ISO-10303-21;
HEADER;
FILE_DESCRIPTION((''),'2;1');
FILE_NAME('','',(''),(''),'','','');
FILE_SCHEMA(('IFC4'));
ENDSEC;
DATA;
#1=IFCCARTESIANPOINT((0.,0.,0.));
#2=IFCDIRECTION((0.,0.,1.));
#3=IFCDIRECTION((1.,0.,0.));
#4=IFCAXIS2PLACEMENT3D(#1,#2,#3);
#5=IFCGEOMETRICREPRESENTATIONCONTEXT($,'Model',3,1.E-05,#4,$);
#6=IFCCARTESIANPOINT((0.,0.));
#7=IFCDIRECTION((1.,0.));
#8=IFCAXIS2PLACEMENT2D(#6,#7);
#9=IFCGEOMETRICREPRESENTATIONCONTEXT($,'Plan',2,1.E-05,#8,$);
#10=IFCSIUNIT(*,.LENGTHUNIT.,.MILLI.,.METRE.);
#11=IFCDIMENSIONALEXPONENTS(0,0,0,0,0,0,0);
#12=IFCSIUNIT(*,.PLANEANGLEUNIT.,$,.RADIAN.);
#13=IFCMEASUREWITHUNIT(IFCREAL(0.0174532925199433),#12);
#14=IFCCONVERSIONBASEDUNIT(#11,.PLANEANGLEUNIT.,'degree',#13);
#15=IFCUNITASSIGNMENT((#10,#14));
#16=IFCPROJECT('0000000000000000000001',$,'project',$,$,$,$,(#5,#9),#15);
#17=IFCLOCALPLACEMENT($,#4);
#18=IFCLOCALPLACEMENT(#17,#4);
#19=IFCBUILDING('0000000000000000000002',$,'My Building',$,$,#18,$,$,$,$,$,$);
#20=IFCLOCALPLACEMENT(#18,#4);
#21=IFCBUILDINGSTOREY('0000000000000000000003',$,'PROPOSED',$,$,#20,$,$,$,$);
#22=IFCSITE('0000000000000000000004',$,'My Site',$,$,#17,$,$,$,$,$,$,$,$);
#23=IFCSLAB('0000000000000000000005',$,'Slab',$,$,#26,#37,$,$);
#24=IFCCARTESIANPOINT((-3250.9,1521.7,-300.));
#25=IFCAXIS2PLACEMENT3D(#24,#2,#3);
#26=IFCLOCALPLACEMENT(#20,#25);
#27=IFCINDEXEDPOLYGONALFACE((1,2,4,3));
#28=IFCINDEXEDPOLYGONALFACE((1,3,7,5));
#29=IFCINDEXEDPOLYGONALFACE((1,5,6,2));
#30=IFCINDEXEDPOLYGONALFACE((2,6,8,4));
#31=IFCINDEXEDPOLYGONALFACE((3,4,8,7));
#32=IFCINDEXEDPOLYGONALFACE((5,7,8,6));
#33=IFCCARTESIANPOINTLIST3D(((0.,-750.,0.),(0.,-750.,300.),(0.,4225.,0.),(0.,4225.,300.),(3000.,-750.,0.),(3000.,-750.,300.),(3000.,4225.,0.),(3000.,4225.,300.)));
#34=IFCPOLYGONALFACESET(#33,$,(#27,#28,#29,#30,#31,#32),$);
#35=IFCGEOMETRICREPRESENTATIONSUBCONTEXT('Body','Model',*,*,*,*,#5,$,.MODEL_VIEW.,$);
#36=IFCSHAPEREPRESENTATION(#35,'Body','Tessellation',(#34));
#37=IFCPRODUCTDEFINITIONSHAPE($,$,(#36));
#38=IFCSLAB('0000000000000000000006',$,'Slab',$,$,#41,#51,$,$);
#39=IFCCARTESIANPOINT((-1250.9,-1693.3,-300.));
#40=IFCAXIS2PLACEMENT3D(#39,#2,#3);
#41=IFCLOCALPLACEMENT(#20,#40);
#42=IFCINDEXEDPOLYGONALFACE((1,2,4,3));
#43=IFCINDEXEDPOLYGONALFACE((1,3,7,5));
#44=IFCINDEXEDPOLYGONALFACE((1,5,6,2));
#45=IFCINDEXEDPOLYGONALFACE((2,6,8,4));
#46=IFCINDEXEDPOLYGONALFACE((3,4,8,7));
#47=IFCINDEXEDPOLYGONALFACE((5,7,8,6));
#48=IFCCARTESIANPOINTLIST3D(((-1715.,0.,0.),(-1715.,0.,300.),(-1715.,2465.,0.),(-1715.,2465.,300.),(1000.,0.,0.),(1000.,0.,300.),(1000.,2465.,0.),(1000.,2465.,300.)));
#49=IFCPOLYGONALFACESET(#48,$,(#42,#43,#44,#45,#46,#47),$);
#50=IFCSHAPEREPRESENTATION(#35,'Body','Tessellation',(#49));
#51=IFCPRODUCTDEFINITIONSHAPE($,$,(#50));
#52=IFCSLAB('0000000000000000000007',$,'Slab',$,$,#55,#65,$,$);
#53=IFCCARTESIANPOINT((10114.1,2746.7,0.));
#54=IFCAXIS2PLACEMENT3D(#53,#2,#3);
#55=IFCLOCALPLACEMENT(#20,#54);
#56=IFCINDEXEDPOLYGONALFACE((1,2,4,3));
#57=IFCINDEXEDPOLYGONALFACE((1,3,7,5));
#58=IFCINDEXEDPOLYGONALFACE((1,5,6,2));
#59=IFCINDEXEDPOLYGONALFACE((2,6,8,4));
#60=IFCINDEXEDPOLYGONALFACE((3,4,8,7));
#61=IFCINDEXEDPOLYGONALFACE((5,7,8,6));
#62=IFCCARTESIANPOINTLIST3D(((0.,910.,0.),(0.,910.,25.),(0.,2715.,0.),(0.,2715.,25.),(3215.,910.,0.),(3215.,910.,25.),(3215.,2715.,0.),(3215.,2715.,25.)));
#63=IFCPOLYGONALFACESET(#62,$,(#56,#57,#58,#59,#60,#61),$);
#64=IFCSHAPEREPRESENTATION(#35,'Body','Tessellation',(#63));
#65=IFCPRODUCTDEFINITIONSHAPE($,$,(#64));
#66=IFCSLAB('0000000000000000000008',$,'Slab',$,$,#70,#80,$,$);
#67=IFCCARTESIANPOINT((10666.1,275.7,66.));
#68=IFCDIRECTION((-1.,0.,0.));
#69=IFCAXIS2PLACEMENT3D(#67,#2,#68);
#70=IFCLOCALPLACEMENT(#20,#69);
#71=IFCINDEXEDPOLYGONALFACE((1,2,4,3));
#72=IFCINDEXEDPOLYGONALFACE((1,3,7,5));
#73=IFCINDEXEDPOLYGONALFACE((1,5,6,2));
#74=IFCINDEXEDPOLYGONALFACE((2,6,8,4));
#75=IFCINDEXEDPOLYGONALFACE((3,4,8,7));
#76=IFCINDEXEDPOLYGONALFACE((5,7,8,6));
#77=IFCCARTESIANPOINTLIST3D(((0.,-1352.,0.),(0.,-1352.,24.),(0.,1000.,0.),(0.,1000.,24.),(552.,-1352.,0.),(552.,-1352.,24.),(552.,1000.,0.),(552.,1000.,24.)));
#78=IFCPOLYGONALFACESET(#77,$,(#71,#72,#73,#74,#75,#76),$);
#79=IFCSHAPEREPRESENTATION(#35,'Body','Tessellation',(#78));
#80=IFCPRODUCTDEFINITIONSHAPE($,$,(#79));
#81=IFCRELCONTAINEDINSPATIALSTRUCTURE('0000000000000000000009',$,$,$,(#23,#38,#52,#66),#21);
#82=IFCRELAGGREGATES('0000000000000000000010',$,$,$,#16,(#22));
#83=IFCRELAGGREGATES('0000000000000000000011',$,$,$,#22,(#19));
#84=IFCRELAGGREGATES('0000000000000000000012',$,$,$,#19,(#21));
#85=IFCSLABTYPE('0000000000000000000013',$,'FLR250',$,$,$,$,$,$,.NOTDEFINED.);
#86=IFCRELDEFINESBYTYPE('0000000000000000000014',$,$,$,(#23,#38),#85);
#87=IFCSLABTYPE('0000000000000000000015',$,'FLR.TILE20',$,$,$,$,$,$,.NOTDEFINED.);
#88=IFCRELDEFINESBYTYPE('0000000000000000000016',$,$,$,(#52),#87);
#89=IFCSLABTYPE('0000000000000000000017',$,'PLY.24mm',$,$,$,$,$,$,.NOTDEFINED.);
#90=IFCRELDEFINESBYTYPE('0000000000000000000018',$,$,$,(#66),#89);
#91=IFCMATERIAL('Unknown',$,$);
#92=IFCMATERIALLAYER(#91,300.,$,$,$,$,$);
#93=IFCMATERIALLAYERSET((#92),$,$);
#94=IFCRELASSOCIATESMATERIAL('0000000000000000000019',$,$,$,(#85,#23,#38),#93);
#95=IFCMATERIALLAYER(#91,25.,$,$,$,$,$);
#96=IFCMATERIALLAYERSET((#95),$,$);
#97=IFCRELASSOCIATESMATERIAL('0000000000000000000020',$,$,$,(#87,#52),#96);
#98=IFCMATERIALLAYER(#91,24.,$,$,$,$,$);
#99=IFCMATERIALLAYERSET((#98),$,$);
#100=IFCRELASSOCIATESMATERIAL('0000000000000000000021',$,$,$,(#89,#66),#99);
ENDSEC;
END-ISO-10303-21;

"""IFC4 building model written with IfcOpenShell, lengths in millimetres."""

from ifc_helpers import new_model, entity, si_unit, converted_unit, frame, origin_with_axes, origin_2d_with_axis, place, context, subcontext, project, spatial, line, indexed_curve, outline, extrude, material, layer, layer_set, layer_usage, type_object, element, save


model = new_model("IFC4")

# Units and contexts
model_context = context("Model", 3, precision=1e-05, world=origin_with_axes())
plan_context = context("Plan", 2, precision=1e-05, world=origin_2d_with_axis())
body_context_1 = subcontext(model_context, "Body", "Model", "MODEL_VIEW")
ifc_project = project(units=[si_unit("LENGTHUNIT", "METRE", prefix="MILLI"), converted_unit("PLANEANGLEUNIT", "degree", entity("IfcReal", 0.0174532925199433), si_unit("PLANEANGLEUNIT", "RADIAN"), dimensions=[0, 0, 0, 0, 0, 0, 0])], contexts=[model_context, plan_context])

# Site, building, storey
site_placement = place(None, origin_with_axes())
site = spatial("IfcSite", under=ifc_project, at=site_placement, Name="My Site")
building_placement = place(site_placement, origin_with_axes())
building = spatial("IfcBuilding", under=site, at=building_placement, Name="My Building")
storey_placement = place(building_placement, origin_with_axes())
storey = spatial("IfcBuildingStorey", under=building, at=storey_placement, Name="PROPOSED")

# Slabs
ifc_material = material(Name="Unknown")
ifc_layer_1 = layer(ifc_material, 300.0)
ifc_layer_set_1 = layer_set([ifc_layer_1])
ifc_layer_usage_1 = layer_usage(ifc_layer_set_1, "AXIS3", "POSITIVE", 0.0)
slab_type_1 = type_object("IfcSlabType", Name="FLR250", PredefinedType="NOTDEFINED", material=ifc_layer_set_1)
slab_1_placement = place(storey_placement, frame((-3250.9, 1521.7, -300.0), z_axis=(0.0, 0.0, 1.0), x_axis=(1.0, 0.0, 0.0)))
element("IfcSlab", 1, at=slab_1_placement, inside=storey, type_object=slab_type_1, material=ifc_layer_usage_1, Name="Slab", context=body_context_1, shape_type="SweptSolid", body=[
    extrude(outline(indexed_curve([(0.0, -750.0), (3000.0, -750.0), (3000.0, 4225.0), (0.0, 4225.0)], segments=[line(4, 1), line(1, 2), line(2, 3), line(3, 4)], self_intersect=False)), None, (0.0, 0.0, 1.0), 300.0),
])
ifc_layer_usage_2 = layer_usage(ifc_layer_set_1, "AXIS3", "POSITIVE", 0.0)
slab_2_placement = place(storey_placement, frame((-1250.9, -1693.3, -300.0), z_axis=(0.0, 0.0, 1.0), x_axis=(1.0, 0.0, 0.0)))
element("IfcSlab", 2, at=slab_2_placement, inside=storey, type_object=slab_type_1, material=ifc_layer_usage_2, Name="Slab", context=body_context_1, shape_type="SweptSolid", body=[
    extrude(outline(indexed_curve([(1000.0, 2465.0), (1000.0, 0.0), (-1715.0, 0.0), (-1715.0, 2465.0)], segments=[line(4, 1), line(1, 2), line(2, 3), line(3, 4)], self_intersect=False)), None, (0.0, 0.0, 1.0), 300.0),
])
ifc_layer_2 = layer(ifc_material, 25.0)
ifc_layer_set_2 = layer_set([ifc_layer_2])
slab_type_2 = type_object("IfcSlabType", Name="FLR.TILE20", PredefinedType="NOTDEFINED", material=ifc_layer_set_2)
ifc_layer_usage_3 = layer_usage(ifc_layer_set_2, "AXIS3", "POSITIVE", 0.0)
slab_3_placement = place(storey_placement, frame((10114.1, 2746.7, 0.0), z_axis=(0.0, 0.0, 1.0), x_axis=(1.0, 0.0, 0.0)))
element("IfcSlab", 3, at=slab_3_placement, inside=storey, type_object=slab_type_2, material=ifc_layer_usage_3, Name="Slab", context=body_context_1, shape_type="SweptSolid", body=[
    extrude(outline(indexed_curve([(3215.0, 2715.0), (3215.0, 910.0), (0.0, 910.0), (0.0, 2715.0)], segments=[line(4, 1), line(1, 2), line(2, 3), line(3, 4)], self_intersect=False)), None, (0.0, 0.0, 1.0), 25.0),
])
ifc_layer_3 = layer(ifc_material, 24.0)
ifc_layer_set_3 = layer_set([ifc_layer_3])
slab_type_3 = type_object("IfcSlabType", Name="PLY.24mm", PredefinedType="NOTDEFINED", material=ifc_layer_set_3)
ifc_layer_usage_4 = layer_usage(ifc_layer_set_3, "AXIS3", "POSITIVE", 0.0)
slab_4_placement = place(storey_placement, frame((10666.1, 275.7, 66.0), z_axis=(0.0, 0.0, 1.0), x_axis=(-1.0, 0.0, 0.0)))
element("IfcSlab", 4, at=slab_4_placement, inside=storey, type_object=slab_type_3, material=ifc_layer_usage_4, Name="Slab", context=body_context_1, shape_type="SweptSolid", body=[
    extrude(outline(indexed_curve([(552.0, -1352.0), (552.0, 1000.0), (0.0, 1000.0), (0.0, -1352.0)], segments=[line(3, 2), line(2, 1), line(1, 4), line(4, 3)], self_intersect=False)), None, (0.0, 0.0, 1.0), 24.0),
])

save(model, "model.ifc")
